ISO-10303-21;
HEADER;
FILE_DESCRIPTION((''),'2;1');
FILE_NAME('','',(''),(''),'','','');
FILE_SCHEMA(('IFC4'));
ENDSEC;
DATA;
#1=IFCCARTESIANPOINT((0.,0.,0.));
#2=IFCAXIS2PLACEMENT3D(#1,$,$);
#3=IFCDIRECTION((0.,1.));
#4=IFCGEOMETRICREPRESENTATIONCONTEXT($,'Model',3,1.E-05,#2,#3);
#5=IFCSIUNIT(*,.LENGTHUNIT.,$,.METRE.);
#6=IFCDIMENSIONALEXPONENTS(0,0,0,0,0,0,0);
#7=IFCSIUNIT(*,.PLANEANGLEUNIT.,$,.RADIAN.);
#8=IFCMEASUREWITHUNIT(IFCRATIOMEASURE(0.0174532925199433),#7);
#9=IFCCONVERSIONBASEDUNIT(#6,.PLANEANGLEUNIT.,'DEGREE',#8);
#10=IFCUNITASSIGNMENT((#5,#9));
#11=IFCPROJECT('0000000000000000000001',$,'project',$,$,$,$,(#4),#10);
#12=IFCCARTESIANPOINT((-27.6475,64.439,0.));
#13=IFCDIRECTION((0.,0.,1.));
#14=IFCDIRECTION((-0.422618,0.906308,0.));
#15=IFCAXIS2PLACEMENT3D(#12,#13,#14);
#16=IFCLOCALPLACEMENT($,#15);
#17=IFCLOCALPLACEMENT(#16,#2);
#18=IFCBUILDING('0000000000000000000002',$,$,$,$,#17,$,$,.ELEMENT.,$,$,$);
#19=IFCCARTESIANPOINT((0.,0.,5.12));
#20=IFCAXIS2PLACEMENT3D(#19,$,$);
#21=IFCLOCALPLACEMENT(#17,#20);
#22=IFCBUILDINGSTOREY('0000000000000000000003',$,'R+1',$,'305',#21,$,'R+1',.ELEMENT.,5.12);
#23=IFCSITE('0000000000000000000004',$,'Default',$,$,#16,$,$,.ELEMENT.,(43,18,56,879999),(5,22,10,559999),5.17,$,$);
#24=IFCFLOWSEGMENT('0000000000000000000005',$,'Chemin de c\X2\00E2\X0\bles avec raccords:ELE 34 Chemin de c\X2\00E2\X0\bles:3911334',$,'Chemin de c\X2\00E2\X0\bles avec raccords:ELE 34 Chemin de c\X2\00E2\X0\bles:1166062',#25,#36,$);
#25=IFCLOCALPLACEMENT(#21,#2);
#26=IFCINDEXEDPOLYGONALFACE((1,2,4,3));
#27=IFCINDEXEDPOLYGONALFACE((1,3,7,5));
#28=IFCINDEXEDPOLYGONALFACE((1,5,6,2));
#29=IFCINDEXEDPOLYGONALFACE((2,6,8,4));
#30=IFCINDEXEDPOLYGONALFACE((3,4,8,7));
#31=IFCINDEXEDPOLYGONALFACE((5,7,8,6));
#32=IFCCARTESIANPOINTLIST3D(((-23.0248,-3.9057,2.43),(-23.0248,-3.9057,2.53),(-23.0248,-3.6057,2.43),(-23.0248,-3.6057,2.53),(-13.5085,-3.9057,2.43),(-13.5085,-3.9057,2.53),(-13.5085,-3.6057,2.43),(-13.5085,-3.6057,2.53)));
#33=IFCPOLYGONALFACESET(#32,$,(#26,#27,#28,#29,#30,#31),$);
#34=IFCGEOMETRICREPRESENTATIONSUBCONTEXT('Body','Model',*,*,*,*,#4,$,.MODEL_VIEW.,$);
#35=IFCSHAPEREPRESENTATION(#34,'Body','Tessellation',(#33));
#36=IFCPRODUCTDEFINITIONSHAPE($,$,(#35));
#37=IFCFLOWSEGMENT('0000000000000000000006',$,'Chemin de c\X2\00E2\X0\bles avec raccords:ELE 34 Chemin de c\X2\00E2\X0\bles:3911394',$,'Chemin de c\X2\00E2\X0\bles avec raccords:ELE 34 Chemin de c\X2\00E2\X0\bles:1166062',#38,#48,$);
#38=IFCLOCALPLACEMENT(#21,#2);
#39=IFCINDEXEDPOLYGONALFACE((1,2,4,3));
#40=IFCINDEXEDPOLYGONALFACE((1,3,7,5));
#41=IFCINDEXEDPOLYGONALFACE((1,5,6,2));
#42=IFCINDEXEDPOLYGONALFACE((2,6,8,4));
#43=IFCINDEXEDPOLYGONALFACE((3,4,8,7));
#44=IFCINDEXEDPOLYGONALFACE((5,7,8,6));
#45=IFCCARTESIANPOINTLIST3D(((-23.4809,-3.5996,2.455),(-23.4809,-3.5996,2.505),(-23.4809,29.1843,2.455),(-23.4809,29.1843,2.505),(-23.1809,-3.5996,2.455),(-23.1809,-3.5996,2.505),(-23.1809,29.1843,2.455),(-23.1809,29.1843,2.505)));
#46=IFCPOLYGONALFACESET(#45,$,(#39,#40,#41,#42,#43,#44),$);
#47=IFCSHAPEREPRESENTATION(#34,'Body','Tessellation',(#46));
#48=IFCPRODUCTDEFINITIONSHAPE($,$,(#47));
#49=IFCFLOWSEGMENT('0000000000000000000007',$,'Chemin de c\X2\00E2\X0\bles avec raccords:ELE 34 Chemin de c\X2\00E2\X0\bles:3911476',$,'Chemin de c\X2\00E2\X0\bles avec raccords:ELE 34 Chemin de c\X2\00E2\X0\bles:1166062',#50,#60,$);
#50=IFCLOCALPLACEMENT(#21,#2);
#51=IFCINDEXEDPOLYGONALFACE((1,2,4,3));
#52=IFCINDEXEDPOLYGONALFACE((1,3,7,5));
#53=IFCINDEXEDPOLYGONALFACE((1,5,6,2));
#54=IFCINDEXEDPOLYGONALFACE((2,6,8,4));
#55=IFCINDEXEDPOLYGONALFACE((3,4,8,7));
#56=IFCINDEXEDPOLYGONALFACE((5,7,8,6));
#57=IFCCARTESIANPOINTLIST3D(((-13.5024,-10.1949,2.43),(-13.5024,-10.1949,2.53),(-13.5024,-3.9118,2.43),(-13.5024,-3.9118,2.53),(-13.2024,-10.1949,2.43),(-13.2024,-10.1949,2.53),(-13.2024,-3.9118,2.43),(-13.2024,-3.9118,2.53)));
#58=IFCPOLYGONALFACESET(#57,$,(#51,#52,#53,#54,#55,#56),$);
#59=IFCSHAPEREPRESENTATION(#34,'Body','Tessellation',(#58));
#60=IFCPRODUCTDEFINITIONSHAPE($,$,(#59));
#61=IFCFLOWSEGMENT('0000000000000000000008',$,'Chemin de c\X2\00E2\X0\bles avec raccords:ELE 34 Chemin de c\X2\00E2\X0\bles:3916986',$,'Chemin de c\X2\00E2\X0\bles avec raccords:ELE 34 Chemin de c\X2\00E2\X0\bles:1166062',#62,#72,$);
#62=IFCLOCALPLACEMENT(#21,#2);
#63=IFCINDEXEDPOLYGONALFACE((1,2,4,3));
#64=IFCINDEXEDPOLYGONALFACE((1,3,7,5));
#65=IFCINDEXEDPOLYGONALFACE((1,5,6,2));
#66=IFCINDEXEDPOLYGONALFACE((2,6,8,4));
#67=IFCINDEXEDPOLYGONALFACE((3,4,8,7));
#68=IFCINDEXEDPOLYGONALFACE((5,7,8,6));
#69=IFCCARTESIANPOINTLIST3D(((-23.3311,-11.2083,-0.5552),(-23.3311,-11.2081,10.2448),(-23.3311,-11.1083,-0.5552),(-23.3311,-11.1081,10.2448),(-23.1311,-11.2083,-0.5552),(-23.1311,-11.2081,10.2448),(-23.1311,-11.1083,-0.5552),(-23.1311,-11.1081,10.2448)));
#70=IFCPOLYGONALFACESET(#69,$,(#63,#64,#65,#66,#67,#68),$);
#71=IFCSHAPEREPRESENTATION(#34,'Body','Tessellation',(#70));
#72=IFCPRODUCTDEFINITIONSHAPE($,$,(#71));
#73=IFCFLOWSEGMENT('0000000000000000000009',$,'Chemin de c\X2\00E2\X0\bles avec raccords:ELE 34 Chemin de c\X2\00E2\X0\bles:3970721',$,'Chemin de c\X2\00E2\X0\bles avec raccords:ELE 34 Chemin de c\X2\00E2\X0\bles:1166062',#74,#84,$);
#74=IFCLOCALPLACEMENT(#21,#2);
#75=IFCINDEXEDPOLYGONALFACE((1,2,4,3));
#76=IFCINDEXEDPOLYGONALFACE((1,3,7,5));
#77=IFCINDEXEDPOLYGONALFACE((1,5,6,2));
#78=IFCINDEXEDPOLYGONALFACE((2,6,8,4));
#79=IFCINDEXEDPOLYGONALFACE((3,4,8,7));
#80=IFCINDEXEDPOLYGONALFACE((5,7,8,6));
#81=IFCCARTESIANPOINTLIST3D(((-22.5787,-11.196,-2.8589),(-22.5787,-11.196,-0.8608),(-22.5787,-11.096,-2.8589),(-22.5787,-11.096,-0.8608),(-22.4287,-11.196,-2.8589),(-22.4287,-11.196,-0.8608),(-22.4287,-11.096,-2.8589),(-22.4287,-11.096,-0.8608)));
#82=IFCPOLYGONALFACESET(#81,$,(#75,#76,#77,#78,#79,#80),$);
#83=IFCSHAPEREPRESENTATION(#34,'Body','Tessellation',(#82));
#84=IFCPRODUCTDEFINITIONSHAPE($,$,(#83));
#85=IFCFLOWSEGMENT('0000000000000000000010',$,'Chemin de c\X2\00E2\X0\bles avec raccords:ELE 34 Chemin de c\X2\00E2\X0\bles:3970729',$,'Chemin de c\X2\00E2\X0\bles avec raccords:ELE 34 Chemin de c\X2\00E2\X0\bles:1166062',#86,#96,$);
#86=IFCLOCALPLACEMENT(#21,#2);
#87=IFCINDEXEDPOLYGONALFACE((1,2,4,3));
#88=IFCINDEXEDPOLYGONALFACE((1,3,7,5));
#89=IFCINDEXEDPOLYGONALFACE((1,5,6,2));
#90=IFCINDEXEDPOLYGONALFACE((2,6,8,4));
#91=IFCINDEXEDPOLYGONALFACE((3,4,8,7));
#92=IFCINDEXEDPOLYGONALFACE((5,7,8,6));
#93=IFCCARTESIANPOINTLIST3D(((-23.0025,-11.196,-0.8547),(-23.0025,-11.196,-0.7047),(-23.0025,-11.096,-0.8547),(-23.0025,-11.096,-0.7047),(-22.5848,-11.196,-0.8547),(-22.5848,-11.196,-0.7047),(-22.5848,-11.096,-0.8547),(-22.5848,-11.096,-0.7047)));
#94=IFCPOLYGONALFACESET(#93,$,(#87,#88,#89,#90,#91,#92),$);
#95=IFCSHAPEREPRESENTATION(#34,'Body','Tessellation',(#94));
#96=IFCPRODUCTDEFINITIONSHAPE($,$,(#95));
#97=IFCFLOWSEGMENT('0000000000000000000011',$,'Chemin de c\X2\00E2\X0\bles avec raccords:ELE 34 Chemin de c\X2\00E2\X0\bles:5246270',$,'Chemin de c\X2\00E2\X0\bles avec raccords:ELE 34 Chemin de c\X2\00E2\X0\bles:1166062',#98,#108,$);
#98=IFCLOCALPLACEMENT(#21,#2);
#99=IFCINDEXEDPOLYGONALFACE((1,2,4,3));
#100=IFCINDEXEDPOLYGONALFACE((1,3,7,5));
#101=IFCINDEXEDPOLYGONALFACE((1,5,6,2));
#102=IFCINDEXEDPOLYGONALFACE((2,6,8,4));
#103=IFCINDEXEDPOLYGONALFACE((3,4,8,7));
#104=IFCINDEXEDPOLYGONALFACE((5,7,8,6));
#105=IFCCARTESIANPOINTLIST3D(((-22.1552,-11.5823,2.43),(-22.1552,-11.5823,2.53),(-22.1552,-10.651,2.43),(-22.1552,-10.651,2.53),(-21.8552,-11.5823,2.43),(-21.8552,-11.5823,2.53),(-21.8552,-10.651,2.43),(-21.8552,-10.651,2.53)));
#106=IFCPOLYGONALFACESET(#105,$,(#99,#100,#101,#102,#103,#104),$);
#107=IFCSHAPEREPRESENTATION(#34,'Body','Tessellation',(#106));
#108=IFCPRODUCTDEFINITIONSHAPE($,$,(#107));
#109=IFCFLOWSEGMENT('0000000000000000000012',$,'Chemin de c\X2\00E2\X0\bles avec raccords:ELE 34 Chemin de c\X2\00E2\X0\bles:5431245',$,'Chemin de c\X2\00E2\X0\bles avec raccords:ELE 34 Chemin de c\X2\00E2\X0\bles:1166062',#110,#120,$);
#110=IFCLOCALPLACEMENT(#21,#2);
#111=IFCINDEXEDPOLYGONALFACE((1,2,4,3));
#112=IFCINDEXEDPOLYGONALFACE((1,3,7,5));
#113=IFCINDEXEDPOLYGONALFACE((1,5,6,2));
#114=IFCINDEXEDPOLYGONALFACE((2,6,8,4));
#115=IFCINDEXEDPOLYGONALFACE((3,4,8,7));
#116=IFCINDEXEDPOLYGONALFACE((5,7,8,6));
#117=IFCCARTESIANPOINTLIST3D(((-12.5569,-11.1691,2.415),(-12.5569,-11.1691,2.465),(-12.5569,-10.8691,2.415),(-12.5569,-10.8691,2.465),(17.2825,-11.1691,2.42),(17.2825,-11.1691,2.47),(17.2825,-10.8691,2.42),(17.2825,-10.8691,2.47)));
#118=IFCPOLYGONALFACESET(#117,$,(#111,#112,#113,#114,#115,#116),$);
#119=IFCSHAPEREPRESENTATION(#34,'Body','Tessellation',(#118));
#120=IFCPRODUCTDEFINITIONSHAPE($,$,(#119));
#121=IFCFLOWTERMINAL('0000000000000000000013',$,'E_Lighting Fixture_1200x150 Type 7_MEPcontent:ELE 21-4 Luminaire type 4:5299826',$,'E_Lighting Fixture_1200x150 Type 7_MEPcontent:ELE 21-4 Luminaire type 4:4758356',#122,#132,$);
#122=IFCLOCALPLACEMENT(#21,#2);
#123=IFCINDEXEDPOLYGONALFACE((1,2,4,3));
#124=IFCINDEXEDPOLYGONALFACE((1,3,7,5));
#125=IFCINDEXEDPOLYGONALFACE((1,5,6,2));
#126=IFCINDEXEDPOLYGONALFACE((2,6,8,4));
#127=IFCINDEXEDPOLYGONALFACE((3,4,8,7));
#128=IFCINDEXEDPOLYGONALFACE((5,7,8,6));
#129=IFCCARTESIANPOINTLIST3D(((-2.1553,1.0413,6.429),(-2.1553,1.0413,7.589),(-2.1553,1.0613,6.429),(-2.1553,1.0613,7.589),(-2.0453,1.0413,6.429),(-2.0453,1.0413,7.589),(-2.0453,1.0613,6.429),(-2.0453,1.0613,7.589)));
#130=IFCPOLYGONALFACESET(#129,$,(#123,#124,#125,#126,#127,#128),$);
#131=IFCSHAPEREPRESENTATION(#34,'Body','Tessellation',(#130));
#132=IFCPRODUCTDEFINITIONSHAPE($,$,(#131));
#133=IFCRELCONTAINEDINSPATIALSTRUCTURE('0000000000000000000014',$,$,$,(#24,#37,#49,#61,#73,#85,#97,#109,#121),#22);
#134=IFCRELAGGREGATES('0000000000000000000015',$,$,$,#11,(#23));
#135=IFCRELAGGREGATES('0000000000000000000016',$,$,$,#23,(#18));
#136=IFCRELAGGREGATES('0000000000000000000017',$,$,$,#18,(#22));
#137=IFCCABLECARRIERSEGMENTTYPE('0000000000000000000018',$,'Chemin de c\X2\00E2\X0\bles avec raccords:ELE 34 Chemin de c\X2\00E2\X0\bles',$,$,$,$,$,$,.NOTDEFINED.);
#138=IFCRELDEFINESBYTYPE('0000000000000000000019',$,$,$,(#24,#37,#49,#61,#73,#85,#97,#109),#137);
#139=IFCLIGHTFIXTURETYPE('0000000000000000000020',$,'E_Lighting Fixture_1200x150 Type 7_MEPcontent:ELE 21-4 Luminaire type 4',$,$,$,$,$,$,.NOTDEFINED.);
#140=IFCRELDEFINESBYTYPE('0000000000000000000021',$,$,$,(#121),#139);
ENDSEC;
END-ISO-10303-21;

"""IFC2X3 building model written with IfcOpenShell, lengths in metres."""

from ifc_helpers import new_model, entity, si_unit, converted_unit, direction, frame, frame_2d, origin, origin_2d_with_axis, place, context, subcontext, project, spatial, rectangle, extrude, source, transform, mapped, type_object, type_shapes, element, save


model = new_model("IFC2X3")

# Units and contexts
model_context = context("Model", 3, precision=1e-05, world=origin(), true_north=direction((0.0, 1.0)))
body_context = subcontext(model_context, "Body", "Model", "MODEL_VIEW")
ifc_project = project(units=[si_unit("LENGTHUNIT", "METRE"), converted_unit("PLANEANGLEUNIT", "DEGREE", entity("IfcRatioMeasure", 0.0174532925199433), si_unit("PLANEANGLEUNIT", "RADIAN"), dimensions=[0, 0, 0, 0, 0, 0, 0])], contexts=[model_context])

# Site, building, storey
site_placement = place(None, frame((-27.6475, 64.439, 0.0), z_axis=(0.0, 0.0, 1.0), x_axis=(-0.422618, 0.906308, 0.0)))
site = spatial("IfcSite", under=ifc_project, at=site_placement, Name="Default", CompositionType="ELEMENT", RefLatitude=(43, 18, 56, 879999), RefLongitude=(5, 22, 10, 559999), RefElevation=5.17)
building_placement = place(site_placement, origin())
building = spatial("IfcBuilding", under=site, at=building_placement, CompositionType="ELEMENT")
storey_placement = place(building_placement, frame((0.0, 0.0, 5.12)))
storey = spatial("IfcBuildingStorey", under=building, at=storey_placement, Name="R+1", ObjectType="305", LongName="R+1", CompositionType="ELEMENT", Elevation=5.12)

# Flow segments
cable_carrier_segment_type = type_object("IfcCableCarrierSegmentType", Name="Chemin de câbles avec raccords:ELE 34 Chemin de câbles", PredefinedType="NOTDEFINED")
flow_segment_1_placement = place(storey_placement, origin())
element("IfcFlowSegment", 1, at=flow_segment_1_placement, inside=storey, type_object=cable_carrier_segment_type, Name="Chemin de câbles avec raccords:ELE 34 Chemin de câbles:3911334", ObjectType="Chemin de câbles avec raccords:ELE 34 Chemin de câbles:1166062", context=body_context, shape_type="SweptSolid", body=[
    extrude(rectangle(XDim=9.5163, YDim=0.3, at=origin_2d_with_axis()), frame((-18.2666, -3.7557, 2.43), z_axis=(0.0, 0.0, 1.0), x_axis=(-1.0, 0.0, 0.0)), (0.0, 0.0, 1.0), 0.1),
])
flow_segment_2_placement = place(storey_placement, origin())
element("IfcFlowSegment", 2, at=flow_segment_2_placement, inside=storey, type_object=cable_carrier_segment_type, Name="Chemin de câbles avec raccords:ELE 34 Chemin de câbles:3911394", ObjectType="Chemin de câbles avec raccords:ELE 34 Chemin de câbles:1166062", context=body_context, shape_type="SweptSolid", body=[
    extrude(rectangle(XDim=32.7839, YDim=0.3, at=frame_2d((0.0, 0.0), x_axis=(1.0, 0.0))), frame((-23.3309, 12.7923, 2.455), z_axis=(0.0, 0.0, 1.0), x_axis=(0.0, 1.0, 0.0)), (0.0, 0.0, 1.0), 0.05),
])
flow_segment_3_placement = place(storey_placement, origin())
element("IfcFlowSegment", 3, at=flow_segment_3_placement, inside=storey, type_object=cable_carrier_segment_type, Name="Chemin de câbles avec raccords:ELE 34 Chemin de câbles:3911476", ObjectType="Chemin de câbles avec raccords:ELE 34 Chemin de câbles:1166062", context=body_context, shape_type="SweptSolid", body=[
    extrude(rectangle(XDim=6.2831, YDim=0.3, at=frame_2d((0.0, 0.0), x_axis=(1.0, 0.0))), frame((-13.3524, -7.0533, 2.43), z_axis=(0.0, 0.0, 1.0), x_axis=(0.0, -1.0, 0.0)), (0.0, 0.0, 1.0), 0.1),
])
flow_segment_4_placement = place(storey_placement, origin())
element("IfcFlowSegment", 4, at=flow_segment_4_placement, inside=storey, type_object=cable_carrier_segment_type, Name="Chemin de câbles avec raccords:ELE 34 Chemin de câbles:3916986", ObjectType="Chemin de câbles avec raccords:ELE 34 Chemin de câbles:1166062", context=body_context, shape_type="SweptSolid", body=[
    extrude(rectangle(XDim=0.2, YDim=0.1, at=frame_2d((0.0, 0.0), x_axis=(1.0, 0.0))), frame((-23.2311, -11.1583, -0.5552), z_axis=(0.0, 0.000014, 1.0), x_axis=(-1.0, 0.000045, 0.0)), (0.0, 0.0, 1.0), 10.8),
])
flow_segment_5_placement = place(storey_placement, origin())
element("IfcFlowSegment", 5, at=flow_segment_5_placement, inside=storey, type_object=cable_carrier_segment_type, Name="Chemin de câbles avec raccords:ELE 34 Chemin de câbles:3970721", ObjectType="Chemin de câbles avec raccords:ELE 34 Chemin de câbles:1166062", context=body_context, shape_type="SweptSolid", body=[
    extrude(rectangle(XDim=0.1, YDim=0.15, at=origin_2d_with_axis()), frame((-22.5037, -11.146, -2.8589), z_axis=(0.0, 0.0, 1.0), x_axis=(0.0, -1.0, 0.0)), (0.0, 0.0, 1.0), 1.9981),
])
flow_segment_6_placement = place(storey_placement, origin())
element("IfcFlowSegment", 6, at=flow_segment_6_placement, inside=storey, type_object=cable_carrier_segment_type, Name="Chemin de câbles avec raccords:ELE 34 Chemin de câbles:3970729", ObjectType="Chemin de câbles avec raccords:ELE 34 Chemin de câbles:1166062", context=body_context, shape_type="SweptSolid", body=[
    extrude(rectangle(XDim=0.4177, YDim=0.1, at=origin_2d_with_axis()), frame((-22.7937, -11.146, -0.8547)), (0.0, 0.0, 1.0), 0.15),
])
flow_segment_7_placement = place(storey_placement, origin())
element("IfcFlowSegment", 7, at=flow_segment_7_placement, inside=storey, type_object=cable_carrier_segment_type, Name="Chemin de câbles avec raccords:ELE 34 Chemin de câbles:5246270", ObjectType="Chemin de câbles avec raccords:ELE 34 Chemin de câbles:1166062", context=body_context, shape_type="SweptSolid", body=[
    extrude(rectangle(XDim=0.9313, YDim=0.3, at=frame_2d((0.0, 0.0), x_axis=(1.0, 0.0))), frame((-22.0052, -11.1166, 2.43), z_axis=(0.0, 0.0, 1.0), x_axis=(0.0, -1.0, 0.0)), (0.0, 0.0, 1.0), 0.1),
])
flow_segment_8_placement = place(storey_placement, origin())
element("IfcFlowSegment", 8, at=flow_segment_8_placement, inside=storey, type_object=cable_carrier_segment_type, Name="Chemin de câbles avec raccords:ELE 34 Chemin de câbles:5431245", ObjectType="Chemin de câbles avec raccords:ELE 34 Chemin de câbles:1166062", context=body_context, shape_type="SweptSolid", body=[
    extrude(rectangle(XDim=29.8394, YDim=0.3, at=origin_2d_with_axis()), frame((2.3628, -11.0191, 2.4175), z_axis=(-0.000168, 0.0, 1.0), x_axis=(1.0, 0.0, 0.000168)), (0.0, 0.0, 1.0), 0.05),
])

# Flow terminal
light_fixture_type = type_object("IfcLightFixtureType", Name="E_Lighting Fixture_1200x150 Type 7_MEPcontent:ELE 21-4 Luminaire type 4", PredefinedType="NOTDEFINED")
shared_shape = source(origin(), body_context, "Body", "SweptSolid", [
    extrude(rectangle(XDim=0.02, YDim=0.11, at=frame_2d((0.0, 0.0), x_axis=(1.0, 0.0))), frame((0.01, 0.0, -0.58), z_axis=(0.0, 0.0, 1.0), x_axis=(-1.0, 0.0, 0.0)), (0.0, 0.0, 1.0), 1.16),
])
type_shapes(light_fixture_type, [shared_shape])
flow_terminal_placement = place(storey_placement, frame((-2.1003, 1.0413, 7.009), z_axis=(0.0, 0.0, 1.0), x_axis=(0.0, 1.0, 0.0)))
element("IfcFlowTerminal", 9, at=flow_terminal_placement, inside=storey, type_object=light_fixture_type, Name="E_Lighting Fixture_1200x150 Type 7_MEPcontent:ELE 21-4 Luminaire type 4:5299826", ObjectType="E_Lighting Fixture_1200x150 Type 7_MEPcontent:ELE 21-4 Luminaire type 4:4758356", context=body_context, shape_type="MappedRepresentation", body=[
    mapped(shared_shape, transform((0.0, 0.0, 0.0), scale=1.0)),
])

save(model, "model.ifc")
